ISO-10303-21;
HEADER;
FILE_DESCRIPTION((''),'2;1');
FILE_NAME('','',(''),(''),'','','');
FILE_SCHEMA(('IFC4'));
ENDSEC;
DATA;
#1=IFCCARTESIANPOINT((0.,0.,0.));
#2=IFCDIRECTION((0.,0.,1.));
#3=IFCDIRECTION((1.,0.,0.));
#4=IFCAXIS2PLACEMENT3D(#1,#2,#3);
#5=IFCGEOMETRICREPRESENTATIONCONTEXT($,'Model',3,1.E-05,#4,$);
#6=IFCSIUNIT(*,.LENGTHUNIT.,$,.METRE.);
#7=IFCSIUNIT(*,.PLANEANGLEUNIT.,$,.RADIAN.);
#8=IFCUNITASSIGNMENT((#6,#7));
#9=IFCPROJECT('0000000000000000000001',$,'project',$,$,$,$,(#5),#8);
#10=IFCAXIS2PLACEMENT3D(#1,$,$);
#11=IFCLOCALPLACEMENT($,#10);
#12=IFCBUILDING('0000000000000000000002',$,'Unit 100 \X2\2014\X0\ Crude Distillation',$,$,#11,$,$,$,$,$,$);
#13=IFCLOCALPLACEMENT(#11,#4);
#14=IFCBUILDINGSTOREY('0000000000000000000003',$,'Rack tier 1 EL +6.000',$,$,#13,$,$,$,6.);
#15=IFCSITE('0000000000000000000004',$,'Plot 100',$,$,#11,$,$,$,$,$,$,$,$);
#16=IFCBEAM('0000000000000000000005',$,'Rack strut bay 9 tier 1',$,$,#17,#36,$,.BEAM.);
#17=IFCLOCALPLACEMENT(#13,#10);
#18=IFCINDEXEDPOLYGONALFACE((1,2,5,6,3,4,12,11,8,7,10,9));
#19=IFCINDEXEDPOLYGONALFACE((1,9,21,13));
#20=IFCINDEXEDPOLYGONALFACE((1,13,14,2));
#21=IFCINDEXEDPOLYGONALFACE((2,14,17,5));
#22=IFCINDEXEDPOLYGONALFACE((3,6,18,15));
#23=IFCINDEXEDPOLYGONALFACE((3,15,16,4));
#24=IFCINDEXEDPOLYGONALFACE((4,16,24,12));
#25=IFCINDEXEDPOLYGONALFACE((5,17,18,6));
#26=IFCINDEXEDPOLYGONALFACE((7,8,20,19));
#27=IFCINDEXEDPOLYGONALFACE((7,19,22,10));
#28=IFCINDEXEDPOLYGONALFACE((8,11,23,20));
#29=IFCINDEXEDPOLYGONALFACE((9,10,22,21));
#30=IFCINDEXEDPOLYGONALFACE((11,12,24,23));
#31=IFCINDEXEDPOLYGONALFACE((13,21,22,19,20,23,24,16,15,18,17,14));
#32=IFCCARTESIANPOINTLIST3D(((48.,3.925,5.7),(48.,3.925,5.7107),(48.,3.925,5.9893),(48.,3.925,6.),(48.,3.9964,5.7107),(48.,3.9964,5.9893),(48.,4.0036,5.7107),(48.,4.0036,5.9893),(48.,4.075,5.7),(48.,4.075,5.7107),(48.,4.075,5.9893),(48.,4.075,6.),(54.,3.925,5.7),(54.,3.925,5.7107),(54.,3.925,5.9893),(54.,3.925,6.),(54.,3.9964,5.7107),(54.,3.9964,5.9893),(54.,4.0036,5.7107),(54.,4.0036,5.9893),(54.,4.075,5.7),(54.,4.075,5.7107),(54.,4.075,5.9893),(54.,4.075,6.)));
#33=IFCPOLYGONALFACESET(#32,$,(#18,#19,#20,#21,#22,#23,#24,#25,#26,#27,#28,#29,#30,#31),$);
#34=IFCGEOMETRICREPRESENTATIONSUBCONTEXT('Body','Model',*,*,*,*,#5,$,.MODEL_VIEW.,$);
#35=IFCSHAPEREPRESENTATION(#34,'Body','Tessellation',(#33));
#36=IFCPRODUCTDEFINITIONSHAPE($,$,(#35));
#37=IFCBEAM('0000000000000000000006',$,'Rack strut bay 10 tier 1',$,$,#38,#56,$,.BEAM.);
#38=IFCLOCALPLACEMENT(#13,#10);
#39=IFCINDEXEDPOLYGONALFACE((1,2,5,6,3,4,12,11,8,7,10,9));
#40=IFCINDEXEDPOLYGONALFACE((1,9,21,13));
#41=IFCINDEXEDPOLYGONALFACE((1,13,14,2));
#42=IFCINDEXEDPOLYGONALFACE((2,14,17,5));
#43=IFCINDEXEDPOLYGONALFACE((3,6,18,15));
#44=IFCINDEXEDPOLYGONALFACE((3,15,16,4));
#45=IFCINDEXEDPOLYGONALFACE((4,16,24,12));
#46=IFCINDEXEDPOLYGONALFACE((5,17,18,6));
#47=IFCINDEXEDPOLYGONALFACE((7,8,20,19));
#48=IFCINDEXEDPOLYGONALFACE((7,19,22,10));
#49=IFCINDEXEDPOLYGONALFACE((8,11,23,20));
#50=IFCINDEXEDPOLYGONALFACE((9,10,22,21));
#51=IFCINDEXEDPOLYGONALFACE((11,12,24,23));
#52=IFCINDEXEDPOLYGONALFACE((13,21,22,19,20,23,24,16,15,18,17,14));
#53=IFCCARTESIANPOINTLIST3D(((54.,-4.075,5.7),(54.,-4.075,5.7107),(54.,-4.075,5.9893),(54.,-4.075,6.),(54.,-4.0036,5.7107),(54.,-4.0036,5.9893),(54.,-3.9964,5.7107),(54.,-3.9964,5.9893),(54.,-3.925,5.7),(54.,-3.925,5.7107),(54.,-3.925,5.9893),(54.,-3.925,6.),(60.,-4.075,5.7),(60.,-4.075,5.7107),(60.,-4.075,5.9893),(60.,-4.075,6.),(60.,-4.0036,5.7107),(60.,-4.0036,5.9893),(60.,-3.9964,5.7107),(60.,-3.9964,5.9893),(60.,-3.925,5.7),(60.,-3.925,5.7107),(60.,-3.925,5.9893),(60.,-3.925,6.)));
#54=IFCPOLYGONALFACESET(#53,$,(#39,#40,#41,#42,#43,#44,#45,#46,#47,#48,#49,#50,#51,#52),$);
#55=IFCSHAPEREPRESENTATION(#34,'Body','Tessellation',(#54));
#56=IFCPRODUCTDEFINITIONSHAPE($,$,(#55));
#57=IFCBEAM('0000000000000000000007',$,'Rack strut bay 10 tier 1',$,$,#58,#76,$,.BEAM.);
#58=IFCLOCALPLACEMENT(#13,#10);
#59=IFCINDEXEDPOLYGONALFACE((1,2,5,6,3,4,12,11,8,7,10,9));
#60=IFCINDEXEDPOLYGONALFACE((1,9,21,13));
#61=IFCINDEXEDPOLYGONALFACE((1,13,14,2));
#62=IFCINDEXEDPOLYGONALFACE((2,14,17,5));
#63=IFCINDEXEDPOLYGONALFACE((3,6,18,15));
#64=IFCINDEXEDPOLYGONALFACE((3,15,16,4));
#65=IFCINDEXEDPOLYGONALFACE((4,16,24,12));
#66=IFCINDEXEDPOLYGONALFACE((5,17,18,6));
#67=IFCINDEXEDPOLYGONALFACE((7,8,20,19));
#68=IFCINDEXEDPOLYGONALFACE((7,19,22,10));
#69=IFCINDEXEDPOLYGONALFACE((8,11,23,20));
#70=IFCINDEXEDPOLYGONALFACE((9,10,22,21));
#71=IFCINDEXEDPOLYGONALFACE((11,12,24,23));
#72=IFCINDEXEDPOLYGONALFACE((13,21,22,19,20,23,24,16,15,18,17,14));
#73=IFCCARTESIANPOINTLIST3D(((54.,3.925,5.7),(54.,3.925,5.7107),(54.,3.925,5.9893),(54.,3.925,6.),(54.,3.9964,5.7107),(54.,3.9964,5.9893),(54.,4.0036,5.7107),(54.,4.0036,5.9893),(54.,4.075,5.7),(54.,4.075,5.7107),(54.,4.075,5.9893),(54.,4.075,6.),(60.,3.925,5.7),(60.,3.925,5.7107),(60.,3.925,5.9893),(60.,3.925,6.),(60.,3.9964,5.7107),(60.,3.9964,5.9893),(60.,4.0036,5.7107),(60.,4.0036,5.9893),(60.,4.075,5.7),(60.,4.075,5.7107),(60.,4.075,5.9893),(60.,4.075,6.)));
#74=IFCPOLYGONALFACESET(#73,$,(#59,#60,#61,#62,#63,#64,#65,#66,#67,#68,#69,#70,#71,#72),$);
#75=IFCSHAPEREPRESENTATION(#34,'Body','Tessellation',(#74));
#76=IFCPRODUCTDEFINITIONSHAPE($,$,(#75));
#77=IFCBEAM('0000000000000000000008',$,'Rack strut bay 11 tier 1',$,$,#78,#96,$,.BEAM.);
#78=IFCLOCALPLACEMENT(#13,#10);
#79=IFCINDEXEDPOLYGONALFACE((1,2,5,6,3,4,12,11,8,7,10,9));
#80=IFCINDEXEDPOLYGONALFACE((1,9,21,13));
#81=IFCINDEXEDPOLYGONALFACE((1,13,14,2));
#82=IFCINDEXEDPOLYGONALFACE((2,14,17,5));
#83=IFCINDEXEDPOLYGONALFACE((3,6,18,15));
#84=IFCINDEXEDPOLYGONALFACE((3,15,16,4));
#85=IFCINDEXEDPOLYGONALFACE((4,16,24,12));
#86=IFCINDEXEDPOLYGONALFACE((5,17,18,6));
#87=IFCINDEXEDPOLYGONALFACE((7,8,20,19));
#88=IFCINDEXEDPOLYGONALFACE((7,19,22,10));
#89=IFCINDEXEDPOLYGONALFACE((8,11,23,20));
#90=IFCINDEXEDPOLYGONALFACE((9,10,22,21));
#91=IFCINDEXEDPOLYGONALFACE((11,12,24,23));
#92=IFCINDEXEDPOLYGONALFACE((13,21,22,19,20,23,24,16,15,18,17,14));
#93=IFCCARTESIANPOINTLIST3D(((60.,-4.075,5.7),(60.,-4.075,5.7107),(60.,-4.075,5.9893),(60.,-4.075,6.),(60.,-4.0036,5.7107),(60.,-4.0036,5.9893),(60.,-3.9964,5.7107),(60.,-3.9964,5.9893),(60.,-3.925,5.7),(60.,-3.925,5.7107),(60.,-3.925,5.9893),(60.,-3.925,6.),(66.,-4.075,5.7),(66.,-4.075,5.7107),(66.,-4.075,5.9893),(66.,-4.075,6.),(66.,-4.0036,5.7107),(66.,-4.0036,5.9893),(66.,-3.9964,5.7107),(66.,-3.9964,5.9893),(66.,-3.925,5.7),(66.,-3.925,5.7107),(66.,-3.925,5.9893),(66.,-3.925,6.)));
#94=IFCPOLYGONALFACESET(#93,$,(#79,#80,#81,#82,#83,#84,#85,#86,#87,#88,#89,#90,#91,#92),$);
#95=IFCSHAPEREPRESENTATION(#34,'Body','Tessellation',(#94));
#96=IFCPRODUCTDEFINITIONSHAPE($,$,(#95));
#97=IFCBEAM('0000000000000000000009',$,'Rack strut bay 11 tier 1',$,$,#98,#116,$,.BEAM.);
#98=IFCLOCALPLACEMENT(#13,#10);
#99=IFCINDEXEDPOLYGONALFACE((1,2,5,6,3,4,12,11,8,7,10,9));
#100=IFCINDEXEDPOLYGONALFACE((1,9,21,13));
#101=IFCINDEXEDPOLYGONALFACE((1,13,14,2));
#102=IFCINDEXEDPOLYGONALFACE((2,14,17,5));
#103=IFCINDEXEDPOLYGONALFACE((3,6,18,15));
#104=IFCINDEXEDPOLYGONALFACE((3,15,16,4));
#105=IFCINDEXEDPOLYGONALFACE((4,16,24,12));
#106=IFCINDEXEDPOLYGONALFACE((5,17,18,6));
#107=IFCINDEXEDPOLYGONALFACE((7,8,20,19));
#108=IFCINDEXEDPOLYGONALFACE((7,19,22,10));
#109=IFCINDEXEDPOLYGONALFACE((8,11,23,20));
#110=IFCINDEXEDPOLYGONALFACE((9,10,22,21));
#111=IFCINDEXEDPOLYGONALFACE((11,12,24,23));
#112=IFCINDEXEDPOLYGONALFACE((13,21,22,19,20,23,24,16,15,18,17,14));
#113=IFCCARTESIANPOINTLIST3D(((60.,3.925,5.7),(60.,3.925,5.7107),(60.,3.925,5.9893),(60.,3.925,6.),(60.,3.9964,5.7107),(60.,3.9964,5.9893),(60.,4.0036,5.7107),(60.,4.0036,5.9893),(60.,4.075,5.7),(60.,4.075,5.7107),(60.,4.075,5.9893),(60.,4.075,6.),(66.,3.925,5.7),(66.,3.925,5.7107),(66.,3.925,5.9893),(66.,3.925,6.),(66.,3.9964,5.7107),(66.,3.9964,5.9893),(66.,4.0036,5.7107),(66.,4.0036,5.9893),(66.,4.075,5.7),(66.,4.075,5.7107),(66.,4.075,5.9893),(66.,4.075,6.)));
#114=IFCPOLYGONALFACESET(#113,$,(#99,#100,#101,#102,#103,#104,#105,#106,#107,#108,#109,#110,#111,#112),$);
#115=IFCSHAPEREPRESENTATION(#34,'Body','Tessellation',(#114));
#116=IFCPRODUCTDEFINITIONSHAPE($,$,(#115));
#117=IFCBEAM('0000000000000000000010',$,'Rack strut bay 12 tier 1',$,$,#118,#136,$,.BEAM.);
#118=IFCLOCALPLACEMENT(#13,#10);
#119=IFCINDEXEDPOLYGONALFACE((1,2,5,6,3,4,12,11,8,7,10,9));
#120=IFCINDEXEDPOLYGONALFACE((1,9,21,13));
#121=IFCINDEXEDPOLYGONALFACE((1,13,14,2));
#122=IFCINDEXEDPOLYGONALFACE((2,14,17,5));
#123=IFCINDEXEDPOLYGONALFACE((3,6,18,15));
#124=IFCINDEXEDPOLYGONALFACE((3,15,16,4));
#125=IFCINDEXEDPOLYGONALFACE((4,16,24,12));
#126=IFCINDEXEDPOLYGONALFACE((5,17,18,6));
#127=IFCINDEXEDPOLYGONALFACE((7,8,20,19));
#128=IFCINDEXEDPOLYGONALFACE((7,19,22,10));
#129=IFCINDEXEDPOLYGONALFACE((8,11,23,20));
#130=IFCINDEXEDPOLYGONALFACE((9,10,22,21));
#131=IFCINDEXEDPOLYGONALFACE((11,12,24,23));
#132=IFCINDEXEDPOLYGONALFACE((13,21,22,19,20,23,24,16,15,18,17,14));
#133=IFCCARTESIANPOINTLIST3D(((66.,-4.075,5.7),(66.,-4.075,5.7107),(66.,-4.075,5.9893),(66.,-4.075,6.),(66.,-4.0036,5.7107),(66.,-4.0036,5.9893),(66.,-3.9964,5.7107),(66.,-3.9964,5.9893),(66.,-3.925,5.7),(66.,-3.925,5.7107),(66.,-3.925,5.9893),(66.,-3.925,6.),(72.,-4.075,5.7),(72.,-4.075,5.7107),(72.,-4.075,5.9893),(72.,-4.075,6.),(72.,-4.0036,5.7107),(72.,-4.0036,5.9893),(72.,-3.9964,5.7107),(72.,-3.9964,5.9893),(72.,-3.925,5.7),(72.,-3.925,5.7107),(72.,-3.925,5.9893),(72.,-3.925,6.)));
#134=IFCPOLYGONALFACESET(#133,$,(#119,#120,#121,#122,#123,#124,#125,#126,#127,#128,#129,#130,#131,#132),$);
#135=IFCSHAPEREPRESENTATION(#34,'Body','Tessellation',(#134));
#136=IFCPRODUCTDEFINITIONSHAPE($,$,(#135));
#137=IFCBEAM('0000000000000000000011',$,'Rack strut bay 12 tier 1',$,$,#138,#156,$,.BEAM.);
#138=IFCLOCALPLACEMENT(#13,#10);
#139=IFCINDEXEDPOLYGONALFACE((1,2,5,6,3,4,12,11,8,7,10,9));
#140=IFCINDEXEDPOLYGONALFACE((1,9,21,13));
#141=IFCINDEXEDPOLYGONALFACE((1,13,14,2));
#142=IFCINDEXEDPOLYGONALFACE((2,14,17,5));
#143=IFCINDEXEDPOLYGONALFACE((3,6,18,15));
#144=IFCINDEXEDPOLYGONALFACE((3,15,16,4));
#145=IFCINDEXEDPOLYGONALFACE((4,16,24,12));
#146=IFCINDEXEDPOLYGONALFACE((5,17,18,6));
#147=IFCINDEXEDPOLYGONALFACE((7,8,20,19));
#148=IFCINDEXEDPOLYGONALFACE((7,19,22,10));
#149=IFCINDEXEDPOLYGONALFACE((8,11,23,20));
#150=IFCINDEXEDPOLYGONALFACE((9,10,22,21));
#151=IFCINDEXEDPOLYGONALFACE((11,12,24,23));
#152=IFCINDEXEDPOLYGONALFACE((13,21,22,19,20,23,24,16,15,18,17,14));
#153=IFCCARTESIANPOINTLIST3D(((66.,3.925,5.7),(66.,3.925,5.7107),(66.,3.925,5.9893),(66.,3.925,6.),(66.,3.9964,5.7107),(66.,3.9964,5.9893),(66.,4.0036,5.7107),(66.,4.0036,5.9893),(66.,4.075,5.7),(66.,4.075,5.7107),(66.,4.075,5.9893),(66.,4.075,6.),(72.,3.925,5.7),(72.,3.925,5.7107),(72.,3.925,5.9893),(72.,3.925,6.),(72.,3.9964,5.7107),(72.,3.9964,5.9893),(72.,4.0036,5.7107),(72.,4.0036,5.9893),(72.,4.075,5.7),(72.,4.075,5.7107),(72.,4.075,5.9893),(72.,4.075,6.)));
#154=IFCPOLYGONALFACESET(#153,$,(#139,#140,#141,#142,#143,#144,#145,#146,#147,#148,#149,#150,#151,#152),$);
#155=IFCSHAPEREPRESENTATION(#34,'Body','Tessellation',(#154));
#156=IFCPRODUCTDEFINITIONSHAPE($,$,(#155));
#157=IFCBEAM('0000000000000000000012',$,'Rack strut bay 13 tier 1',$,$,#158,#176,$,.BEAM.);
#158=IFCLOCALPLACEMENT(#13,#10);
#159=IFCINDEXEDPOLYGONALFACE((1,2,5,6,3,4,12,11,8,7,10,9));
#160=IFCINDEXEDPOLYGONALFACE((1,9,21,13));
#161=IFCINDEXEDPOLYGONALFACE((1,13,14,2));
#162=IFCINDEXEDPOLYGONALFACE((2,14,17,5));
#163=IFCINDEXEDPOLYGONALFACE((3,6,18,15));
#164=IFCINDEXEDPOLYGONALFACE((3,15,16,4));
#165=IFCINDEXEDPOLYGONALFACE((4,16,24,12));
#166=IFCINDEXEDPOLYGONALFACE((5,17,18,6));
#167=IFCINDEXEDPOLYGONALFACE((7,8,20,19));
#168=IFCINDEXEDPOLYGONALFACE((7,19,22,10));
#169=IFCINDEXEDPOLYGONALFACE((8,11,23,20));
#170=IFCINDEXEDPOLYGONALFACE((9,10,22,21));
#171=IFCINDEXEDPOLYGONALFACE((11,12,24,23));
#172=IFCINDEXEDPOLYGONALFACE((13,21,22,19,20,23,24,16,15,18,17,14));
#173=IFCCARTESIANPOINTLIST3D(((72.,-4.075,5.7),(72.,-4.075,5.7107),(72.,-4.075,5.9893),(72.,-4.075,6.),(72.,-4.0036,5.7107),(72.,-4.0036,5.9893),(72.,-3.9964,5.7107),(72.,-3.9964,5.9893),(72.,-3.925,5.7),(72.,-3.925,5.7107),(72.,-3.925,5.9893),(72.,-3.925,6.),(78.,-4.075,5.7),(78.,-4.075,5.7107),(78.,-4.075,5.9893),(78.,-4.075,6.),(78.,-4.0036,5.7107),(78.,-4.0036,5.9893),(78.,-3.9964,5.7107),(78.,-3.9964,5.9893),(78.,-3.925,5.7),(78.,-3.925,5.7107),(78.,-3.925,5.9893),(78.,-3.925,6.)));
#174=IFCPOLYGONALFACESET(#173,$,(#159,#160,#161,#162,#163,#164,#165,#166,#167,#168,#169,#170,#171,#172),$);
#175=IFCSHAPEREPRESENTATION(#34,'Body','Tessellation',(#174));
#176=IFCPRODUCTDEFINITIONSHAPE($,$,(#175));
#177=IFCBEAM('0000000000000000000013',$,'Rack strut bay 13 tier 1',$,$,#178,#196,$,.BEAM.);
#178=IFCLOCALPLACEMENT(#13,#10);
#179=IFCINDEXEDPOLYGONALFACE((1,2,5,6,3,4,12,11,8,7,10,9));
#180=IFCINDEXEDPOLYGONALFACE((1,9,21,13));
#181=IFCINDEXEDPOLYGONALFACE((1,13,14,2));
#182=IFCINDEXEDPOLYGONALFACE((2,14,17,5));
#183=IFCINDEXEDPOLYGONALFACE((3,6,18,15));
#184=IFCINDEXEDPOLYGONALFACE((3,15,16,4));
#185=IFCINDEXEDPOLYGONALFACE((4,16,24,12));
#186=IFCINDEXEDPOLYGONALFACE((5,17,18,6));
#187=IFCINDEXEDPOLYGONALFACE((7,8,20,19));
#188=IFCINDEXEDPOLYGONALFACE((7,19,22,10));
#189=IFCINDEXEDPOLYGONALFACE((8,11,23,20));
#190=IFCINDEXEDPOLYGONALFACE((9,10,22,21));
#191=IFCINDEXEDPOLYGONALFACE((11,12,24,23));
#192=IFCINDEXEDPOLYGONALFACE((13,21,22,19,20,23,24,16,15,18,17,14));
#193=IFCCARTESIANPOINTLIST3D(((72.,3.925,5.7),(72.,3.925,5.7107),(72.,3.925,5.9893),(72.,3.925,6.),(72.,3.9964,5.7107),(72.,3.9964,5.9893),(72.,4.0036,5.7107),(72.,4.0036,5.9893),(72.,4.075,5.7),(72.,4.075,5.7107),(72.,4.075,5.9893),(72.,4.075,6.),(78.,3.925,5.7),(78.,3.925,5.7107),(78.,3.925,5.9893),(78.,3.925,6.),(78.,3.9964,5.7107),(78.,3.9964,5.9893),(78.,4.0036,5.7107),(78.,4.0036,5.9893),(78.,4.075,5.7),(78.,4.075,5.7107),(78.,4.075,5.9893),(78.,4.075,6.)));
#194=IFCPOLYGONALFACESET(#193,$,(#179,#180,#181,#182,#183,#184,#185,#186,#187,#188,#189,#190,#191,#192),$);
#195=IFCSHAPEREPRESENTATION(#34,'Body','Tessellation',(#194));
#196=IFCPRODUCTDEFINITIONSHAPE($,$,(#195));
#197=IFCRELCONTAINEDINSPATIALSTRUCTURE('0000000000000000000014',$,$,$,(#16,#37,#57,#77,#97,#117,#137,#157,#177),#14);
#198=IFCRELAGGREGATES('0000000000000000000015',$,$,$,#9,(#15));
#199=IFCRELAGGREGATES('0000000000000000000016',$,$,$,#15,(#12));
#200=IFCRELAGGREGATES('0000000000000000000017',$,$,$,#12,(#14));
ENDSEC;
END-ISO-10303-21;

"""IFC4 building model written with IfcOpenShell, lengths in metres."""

from ifc_helpers import new_model, si_unit, frame, origin, origin_with_axes, origin_2d, place, context, subcontext, project, spatial, i_section, extrude, element, save


model = new_model("IFC4")

# Units and contexts
model_context = context("Model", 3, precision=1e-05, world=origin_with_axes())
body_context = subcontext(model_context, "Body", "Model", "MODEL_VIEW")
ifc_project = project(units=[si_unit("LENGTHUNIT", "METRE"), si_unit("PLANEANGLEUNIT", "RADIAN")], contexts=[model_context])

# Site, building, storey
placement = place(None, origin())
site = spatial("IfcSite", under=ifc_project, at=placement, Name="Plot 100")
building = spatial("IfcBuilding", under=site, at=placement, Name="Unit 100 — Crude Distillation")
storey_placement = place(placement, origin_with_axes())
storey = spatial("IfcBuildingStorey", under=building, at=storey_placement, Name="Rack tier 1 EL +6.000", Elevation=6.0)

# Beams
beam_1_placement = place(storey_placement, origin_with_axes())
element("IfcBeam", 1, at=beam_1_placement, inside=storey, Name="Rack strut bay 9 tier 1", PredefinedType="BEAM", context=body_context, shape_type="SweptSolid", body=[
    extrude(i_section(OverallWidth=0.15, OverallDepth=0.3, WebThickness=0.0071, FlangeThickness=0.0107, at=origin_2d()), frame((48.0, 4.0, 5.85), z_axis=(1.0, 0.0, 0.0), x_axis=(0.0, 1.0, 0.0)), (0.0, 0.0, 1.0), 6.0),
])
beam_2_placement = place(storey_placement, origin_with_axes())
element("IfcBeam", 2, at=beam_2_placement, inside=storey, Name="Rack strut bay 10 tier 1", PredefinedType="BEAM", context=body_context, shape_type="SweptSolid", body=[
    extrude(i_section(OverallWidth=0.15, OverallDepth=0.3, WebThickness=0.0071, FlangeThickness=0.0107, at=origin_2d()), frame((54.0, -4.0, 5.85), z_axis=(1.0, 0.0, 0.0), x_axis=(0.0, 1.0, 0.0)), (0.0, 0.0, 1.0), 6.0),
])
beam_3_placement = place(storey_placement, origin_with_axes())
element("IfcBeam", 3, at=beam_3_placement, inside=storey, Name="Rack strut bay 10 tier 1", PredefinedType="BEAM", context=body_context, shape_type="SweptSolid", body=[
    extrude(i_section(OverallWidth=0.15, OverallDepth=0.3, WebThickness=0.0071, FlangeThickness=0.0107, at=origin_2d()), frame((54.0, 4.0, 5.85), z_axis=(1.0, 0.0, 0.0), x_axis=(0.0, 1.0, 0.0)), (0.0, 0.0, 1.0), 6.0),
])
beam_4_placement = place(storey_placement, origin_with_axes())
element("IfcBeam", 4, at=beam_4_placement, inside=storey, Name="Rack strut bay 11 tier 1", PredefinedType="BEAM", context=body_context, shape_type="SweptSolid", body=[
    extrude(i_section(OverallWidth=0.15, OverallDepth=0.3, WebThickness=0.0071, FlangeThickness=0.0107, at=origin_2d()), frame((60.0, -4.0, 5.85), z_axis=(1.0, 0.0, 0.0), x_axis=(0.0, 1.0, 0.0)), (0.0, 0.0, 1.0), 6.0),
])
beam_5_placement = place(storey_placement, origin_with_axes())
element("IfcBeam", 5, at=beam_5_placement, inside=storey, Name="Rack strut bay 11 tier 1", PredefinedType="BEAM", context=body_context, shape_type="SweptSolid", body=[
    extrude(i_section(OverallWidth=0.15, OverallDepth=0.3, WebThickness=0.0071, FlangeThickness=0.0107, at=origin_2d()), frame((60.0, 4.0, 5.85), z_axis=(1.0, 0.0, 0.0), x_axis=(0.0, 1.0, 0.0)), (0.0, 0.0, 1.0), 6.0),
])
beam_6_placement = place(storey_placement, origin_with_axes())
element("IfcBeam", 6, at=beam_6_placement, inside=storey, Name="Rack strut bay 12 tier 1", PredefinedType="BEAM", context=body_context, shape_type="SweptSolid", body=[
    extrude(i_section(OverallWidth=0.15, OverallDepth=0.3, WebThickness=0.0071, FlangeThickness=0.0107, at=origin_2d()), frame((66.0, -4.0, 5.85), z_axis=(1.0, 0.0, 0.0), x_axis=(0.0, 1.0, 0.0)), (0.0, 0.0, 1.0), 6.0),
])
beam_7_placement = place(storey_placement, origin_with_axes())
element("IfcBeam", 7, at=beam_7_placement, inside=storey, Name="Rack strut bay 12 tier 1", PredefinedType="BEAM", context=body_context, shape_type="SweptSolid", body=[
    extrude(i_section(OverallWidth=0.15, OverallDepth=0.3, WebThickness=0.0071, FlangeThickness=0.0107, at=origin_2d()), frame((66.0, 4.0, 5.85), z_axis=(1.0, 0.0, 0.0), x_axis=(0.0, 1.0, 0.0)), (0.0, 0.0, 1.0), 6.0),
])
beam_8_placement = place(storey_placement, origin_with_axes())
element("IfcBeam", 8, at=beam_8_placement, inside=storey, Name="Rack strut bay 13 tier 1", PredefinedType="BEAM", context=body_context, shape_type="SweptSolid", body=[
    extrude(i_section(OverallWidth=0.15, OverallDepth=0.3, WebThickness=0.0071, FlangeThickness=0.0107, at=origin_2d()), frame((72.0, -4.0, 5.85), z_axis=(1.0, 0.0, 0.0), x_axis=(0.0, 1.0, 0.0)), (0.0, 0.0, 1.0), 6.0),
])
beam_9_placement = place(storey_placement, origin_with_axes())
element("IfcBeam", 9, at=beam_9_placement, inside=storey, Name="Rack strut bay 13 tier 1", PredefinedType="BEAM", context=body_context, shape_type="SweptSolid", body=[
    extrude(i_section(OverallWidth=0.15, OverallDepth=0.3, WebThickness=0.0071, FlangeThickness=0.0107, at=origin_2d()), frame((72.0, 4.0, 5.85), z_axis=(1.0, 0.0, 0.0), x_axis=(0.0, 1.0, 0.0)), (0.0, 0.0, 1.0), 6.0),
])

save(model, "model.ifc")
